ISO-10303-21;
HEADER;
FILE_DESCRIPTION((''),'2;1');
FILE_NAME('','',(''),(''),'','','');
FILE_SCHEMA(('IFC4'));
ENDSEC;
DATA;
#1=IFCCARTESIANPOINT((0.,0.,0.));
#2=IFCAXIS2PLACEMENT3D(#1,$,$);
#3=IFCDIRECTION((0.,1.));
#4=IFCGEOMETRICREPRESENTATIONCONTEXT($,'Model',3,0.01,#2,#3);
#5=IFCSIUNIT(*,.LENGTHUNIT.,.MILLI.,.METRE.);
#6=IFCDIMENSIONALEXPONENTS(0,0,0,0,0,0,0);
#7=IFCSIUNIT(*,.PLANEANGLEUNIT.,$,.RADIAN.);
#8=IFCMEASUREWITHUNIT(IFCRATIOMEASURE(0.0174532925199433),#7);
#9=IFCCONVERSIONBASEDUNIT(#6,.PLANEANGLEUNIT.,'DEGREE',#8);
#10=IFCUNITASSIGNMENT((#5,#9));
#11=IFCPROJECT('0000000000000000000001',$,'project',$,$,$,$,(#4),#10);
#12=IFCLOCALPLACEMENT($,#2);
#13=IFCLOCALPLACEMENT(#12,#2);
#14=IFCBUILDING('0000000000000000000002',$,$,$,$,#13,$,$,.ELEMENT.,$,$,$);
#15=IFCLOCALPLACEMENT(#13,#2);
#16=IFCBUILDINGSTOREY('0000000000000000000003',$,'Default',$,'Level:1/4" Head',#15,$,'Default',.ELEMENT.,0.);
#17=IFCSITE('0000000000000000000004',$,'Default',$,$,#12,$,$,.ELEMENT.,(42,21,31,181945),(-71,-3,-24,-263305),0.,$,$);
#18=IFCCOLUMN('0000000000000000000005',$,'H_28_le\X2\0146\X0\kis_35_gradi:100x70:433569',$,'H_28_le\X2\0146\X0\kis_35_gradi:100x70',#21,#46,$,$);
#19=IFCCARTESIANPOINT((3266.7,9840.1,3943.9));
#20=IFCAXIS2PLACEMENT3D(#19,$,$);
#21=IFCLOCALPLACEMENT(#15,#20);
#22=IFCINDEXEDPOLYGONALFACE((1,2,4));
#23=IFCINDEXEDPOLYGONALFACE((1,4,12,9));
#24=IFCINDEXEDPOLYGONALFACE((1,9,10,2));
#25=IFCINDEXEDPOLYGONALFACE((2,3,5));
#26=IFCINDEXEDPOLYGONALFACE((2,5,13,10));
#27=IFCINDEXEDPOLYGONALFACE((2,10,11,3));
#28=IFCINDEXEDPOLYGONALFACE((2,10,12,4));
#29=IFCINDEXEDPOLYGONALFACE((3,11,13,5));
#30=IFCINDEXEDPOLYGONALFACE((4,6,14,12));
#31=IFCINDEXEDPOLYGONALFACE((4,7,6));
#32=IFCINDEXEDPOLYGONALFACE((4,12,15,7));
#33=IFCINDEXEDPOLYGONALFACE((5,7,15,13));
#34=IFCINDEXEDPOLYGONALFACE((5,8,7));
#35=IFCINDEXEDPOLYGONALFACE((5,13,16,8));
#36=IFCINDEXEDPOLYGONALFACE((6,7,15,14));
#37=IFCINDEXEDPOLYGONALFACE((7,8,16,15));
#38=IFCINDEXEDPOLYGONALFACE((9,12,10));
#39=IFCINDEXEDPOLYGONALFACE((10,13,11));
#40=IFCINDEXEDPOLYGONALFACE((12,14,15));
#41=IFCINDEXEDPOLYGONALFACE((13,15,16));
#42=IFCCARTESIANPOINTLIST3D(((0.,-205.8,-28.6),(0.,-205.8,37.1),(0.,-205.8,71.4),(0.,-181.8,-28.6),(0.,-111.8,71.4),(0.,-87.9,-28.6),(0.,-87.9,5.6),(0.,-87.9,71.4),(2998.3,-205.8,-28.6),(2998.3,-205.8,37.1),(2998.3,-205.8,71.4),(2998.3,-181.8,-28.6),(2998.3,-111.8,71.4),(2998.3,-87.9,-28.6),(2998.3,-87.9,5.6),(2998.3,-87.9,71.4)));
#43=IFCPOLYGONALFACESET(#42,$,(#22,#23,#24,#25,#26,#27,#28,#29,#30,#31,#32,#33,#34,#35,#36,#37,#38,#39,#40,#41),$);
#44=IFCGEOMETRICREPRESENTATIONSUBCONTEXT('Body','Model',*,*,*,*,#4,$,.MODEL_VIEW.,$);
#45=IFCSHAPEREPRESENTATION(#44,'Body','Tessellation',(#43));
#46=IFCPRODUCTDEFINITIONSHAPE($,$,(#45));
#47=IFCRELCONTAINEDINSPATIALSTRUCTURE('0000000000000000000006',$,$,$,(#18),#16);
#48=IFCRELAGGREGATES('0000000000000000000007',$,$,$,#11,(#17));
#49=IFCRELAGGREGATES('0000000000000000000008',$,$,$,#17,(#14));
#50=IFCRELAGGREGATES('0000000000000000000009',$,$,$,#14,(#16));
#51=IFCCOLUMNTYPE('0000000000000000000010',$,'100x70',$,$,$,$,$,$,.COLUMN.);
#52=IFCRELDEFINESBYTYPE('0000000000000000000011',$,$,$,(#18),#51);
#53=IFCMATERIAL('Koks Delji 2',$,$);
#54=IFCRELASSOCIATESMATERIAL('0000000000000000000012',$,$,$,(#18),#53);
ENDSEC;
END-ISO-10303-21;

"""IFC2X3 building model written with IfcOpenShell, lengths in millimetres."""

from ifc_helpers import new_model, entity, si_unit, converted_unit, direction, frame, frame_2d, origin, place, context, subcontext, project, spatial, rectangle, extrude, boolean, source, transform, mapped, material, type_object, type_shapes, element, save


model = new_model("IFC2X3")

# Units and contexts
model_context = context("Model", 3, precision=0.01, world=origin(), true_north=direction((0.0, 1.0)))
body_context = subcontext(model_context, "Body", "Model", "MODEL_VIEW")
ifc_project = project(units=[si_unit("LENGTHUNIT", "METRE", prefix="MILLI"), converted_unit("PLANEANGLEUNIT", "DEGREE", entity("IfcRatioMeasure", 0.0174532925199433), si_unit("PLANEANGLEUNIT", "RADIAN"), dimensions=[0, 0, 0, 0, 0, 0, 0])], contexts=[model_context])

# Site, building, storey
site_placement = place(None, origin())
site = spatial("IfcSite", under=ifc_project, at=site_placement, Name="Default", CompositionType="ELEMENT", RefLatitude=(42, 21, 31, 181945), RefLongitude=(-71, -3, -24, -263305), RefElevation=0.0)
building_placement = place(site_placement, origin())
building = spatial("IfcBuilding", under=site, at=building_placement, CompositionType="ELEMENT")
storey_placement = place(building_placement, origin())
storey = spatial("IfcBuildingStorey", under=building, at=storey_placement, Name="Default", ObjectType="Level:1/4\" Head", LongName="Default", CompositionType="ELEMENT", Elevation=0.0)

# Column
ifc_material_1 = material(Name="Koks Delji 2")
column_type = type_object("IfcColumnType", Name="100x70", PredefinedType="COLUMN")
shared_shape_1 = source(origin(), body_context, "Body", "CSG", [
    boolean("DIFFERENCE", extrude(rectangle(XDim=2998.3, YDim=117.9, at=frame_2d((0.0, 0.0), x_axis=(1.0, 0.0))), frame((1499.1, -146.8, -28.6)), (0.0, 0.0, 1.0), 100.0), extrude(rectangle(XDim=70.0, YDim=100.0, at=frame_2d((0.0, 0.0), x_axis=(0.0, 1.0))), frame((0.0, -146.8, 21.4), z_axis=(-1.0, 0.0, 0.0), x_axis=(0.0, -0.939693, -0.34202)), (0.0, 0.0, -1.0), 2998.3)),
])
type_shapes(column_type, [shared_shape_1])
for number, where, name in (
    (1, (3266.7, 9840.1, 3943.9), "H_28_leņkis_35_gradi:100x70:433569"),
):
    element("IfcColumn", number, at=place(storey_placement, frame(where)), inside=storey, type_object=column_type, material=ifc_material_1, Name=name, ObjectType="H_28_leņkis_35_gradi:100x70", context=body_context, shape_type="MappedRepresentation", body=[
        mapped(shared_shape_1, transform((0.0, 0.0, 0.0), scale=1.0)),
    ])

save(model, "model.ifc")
